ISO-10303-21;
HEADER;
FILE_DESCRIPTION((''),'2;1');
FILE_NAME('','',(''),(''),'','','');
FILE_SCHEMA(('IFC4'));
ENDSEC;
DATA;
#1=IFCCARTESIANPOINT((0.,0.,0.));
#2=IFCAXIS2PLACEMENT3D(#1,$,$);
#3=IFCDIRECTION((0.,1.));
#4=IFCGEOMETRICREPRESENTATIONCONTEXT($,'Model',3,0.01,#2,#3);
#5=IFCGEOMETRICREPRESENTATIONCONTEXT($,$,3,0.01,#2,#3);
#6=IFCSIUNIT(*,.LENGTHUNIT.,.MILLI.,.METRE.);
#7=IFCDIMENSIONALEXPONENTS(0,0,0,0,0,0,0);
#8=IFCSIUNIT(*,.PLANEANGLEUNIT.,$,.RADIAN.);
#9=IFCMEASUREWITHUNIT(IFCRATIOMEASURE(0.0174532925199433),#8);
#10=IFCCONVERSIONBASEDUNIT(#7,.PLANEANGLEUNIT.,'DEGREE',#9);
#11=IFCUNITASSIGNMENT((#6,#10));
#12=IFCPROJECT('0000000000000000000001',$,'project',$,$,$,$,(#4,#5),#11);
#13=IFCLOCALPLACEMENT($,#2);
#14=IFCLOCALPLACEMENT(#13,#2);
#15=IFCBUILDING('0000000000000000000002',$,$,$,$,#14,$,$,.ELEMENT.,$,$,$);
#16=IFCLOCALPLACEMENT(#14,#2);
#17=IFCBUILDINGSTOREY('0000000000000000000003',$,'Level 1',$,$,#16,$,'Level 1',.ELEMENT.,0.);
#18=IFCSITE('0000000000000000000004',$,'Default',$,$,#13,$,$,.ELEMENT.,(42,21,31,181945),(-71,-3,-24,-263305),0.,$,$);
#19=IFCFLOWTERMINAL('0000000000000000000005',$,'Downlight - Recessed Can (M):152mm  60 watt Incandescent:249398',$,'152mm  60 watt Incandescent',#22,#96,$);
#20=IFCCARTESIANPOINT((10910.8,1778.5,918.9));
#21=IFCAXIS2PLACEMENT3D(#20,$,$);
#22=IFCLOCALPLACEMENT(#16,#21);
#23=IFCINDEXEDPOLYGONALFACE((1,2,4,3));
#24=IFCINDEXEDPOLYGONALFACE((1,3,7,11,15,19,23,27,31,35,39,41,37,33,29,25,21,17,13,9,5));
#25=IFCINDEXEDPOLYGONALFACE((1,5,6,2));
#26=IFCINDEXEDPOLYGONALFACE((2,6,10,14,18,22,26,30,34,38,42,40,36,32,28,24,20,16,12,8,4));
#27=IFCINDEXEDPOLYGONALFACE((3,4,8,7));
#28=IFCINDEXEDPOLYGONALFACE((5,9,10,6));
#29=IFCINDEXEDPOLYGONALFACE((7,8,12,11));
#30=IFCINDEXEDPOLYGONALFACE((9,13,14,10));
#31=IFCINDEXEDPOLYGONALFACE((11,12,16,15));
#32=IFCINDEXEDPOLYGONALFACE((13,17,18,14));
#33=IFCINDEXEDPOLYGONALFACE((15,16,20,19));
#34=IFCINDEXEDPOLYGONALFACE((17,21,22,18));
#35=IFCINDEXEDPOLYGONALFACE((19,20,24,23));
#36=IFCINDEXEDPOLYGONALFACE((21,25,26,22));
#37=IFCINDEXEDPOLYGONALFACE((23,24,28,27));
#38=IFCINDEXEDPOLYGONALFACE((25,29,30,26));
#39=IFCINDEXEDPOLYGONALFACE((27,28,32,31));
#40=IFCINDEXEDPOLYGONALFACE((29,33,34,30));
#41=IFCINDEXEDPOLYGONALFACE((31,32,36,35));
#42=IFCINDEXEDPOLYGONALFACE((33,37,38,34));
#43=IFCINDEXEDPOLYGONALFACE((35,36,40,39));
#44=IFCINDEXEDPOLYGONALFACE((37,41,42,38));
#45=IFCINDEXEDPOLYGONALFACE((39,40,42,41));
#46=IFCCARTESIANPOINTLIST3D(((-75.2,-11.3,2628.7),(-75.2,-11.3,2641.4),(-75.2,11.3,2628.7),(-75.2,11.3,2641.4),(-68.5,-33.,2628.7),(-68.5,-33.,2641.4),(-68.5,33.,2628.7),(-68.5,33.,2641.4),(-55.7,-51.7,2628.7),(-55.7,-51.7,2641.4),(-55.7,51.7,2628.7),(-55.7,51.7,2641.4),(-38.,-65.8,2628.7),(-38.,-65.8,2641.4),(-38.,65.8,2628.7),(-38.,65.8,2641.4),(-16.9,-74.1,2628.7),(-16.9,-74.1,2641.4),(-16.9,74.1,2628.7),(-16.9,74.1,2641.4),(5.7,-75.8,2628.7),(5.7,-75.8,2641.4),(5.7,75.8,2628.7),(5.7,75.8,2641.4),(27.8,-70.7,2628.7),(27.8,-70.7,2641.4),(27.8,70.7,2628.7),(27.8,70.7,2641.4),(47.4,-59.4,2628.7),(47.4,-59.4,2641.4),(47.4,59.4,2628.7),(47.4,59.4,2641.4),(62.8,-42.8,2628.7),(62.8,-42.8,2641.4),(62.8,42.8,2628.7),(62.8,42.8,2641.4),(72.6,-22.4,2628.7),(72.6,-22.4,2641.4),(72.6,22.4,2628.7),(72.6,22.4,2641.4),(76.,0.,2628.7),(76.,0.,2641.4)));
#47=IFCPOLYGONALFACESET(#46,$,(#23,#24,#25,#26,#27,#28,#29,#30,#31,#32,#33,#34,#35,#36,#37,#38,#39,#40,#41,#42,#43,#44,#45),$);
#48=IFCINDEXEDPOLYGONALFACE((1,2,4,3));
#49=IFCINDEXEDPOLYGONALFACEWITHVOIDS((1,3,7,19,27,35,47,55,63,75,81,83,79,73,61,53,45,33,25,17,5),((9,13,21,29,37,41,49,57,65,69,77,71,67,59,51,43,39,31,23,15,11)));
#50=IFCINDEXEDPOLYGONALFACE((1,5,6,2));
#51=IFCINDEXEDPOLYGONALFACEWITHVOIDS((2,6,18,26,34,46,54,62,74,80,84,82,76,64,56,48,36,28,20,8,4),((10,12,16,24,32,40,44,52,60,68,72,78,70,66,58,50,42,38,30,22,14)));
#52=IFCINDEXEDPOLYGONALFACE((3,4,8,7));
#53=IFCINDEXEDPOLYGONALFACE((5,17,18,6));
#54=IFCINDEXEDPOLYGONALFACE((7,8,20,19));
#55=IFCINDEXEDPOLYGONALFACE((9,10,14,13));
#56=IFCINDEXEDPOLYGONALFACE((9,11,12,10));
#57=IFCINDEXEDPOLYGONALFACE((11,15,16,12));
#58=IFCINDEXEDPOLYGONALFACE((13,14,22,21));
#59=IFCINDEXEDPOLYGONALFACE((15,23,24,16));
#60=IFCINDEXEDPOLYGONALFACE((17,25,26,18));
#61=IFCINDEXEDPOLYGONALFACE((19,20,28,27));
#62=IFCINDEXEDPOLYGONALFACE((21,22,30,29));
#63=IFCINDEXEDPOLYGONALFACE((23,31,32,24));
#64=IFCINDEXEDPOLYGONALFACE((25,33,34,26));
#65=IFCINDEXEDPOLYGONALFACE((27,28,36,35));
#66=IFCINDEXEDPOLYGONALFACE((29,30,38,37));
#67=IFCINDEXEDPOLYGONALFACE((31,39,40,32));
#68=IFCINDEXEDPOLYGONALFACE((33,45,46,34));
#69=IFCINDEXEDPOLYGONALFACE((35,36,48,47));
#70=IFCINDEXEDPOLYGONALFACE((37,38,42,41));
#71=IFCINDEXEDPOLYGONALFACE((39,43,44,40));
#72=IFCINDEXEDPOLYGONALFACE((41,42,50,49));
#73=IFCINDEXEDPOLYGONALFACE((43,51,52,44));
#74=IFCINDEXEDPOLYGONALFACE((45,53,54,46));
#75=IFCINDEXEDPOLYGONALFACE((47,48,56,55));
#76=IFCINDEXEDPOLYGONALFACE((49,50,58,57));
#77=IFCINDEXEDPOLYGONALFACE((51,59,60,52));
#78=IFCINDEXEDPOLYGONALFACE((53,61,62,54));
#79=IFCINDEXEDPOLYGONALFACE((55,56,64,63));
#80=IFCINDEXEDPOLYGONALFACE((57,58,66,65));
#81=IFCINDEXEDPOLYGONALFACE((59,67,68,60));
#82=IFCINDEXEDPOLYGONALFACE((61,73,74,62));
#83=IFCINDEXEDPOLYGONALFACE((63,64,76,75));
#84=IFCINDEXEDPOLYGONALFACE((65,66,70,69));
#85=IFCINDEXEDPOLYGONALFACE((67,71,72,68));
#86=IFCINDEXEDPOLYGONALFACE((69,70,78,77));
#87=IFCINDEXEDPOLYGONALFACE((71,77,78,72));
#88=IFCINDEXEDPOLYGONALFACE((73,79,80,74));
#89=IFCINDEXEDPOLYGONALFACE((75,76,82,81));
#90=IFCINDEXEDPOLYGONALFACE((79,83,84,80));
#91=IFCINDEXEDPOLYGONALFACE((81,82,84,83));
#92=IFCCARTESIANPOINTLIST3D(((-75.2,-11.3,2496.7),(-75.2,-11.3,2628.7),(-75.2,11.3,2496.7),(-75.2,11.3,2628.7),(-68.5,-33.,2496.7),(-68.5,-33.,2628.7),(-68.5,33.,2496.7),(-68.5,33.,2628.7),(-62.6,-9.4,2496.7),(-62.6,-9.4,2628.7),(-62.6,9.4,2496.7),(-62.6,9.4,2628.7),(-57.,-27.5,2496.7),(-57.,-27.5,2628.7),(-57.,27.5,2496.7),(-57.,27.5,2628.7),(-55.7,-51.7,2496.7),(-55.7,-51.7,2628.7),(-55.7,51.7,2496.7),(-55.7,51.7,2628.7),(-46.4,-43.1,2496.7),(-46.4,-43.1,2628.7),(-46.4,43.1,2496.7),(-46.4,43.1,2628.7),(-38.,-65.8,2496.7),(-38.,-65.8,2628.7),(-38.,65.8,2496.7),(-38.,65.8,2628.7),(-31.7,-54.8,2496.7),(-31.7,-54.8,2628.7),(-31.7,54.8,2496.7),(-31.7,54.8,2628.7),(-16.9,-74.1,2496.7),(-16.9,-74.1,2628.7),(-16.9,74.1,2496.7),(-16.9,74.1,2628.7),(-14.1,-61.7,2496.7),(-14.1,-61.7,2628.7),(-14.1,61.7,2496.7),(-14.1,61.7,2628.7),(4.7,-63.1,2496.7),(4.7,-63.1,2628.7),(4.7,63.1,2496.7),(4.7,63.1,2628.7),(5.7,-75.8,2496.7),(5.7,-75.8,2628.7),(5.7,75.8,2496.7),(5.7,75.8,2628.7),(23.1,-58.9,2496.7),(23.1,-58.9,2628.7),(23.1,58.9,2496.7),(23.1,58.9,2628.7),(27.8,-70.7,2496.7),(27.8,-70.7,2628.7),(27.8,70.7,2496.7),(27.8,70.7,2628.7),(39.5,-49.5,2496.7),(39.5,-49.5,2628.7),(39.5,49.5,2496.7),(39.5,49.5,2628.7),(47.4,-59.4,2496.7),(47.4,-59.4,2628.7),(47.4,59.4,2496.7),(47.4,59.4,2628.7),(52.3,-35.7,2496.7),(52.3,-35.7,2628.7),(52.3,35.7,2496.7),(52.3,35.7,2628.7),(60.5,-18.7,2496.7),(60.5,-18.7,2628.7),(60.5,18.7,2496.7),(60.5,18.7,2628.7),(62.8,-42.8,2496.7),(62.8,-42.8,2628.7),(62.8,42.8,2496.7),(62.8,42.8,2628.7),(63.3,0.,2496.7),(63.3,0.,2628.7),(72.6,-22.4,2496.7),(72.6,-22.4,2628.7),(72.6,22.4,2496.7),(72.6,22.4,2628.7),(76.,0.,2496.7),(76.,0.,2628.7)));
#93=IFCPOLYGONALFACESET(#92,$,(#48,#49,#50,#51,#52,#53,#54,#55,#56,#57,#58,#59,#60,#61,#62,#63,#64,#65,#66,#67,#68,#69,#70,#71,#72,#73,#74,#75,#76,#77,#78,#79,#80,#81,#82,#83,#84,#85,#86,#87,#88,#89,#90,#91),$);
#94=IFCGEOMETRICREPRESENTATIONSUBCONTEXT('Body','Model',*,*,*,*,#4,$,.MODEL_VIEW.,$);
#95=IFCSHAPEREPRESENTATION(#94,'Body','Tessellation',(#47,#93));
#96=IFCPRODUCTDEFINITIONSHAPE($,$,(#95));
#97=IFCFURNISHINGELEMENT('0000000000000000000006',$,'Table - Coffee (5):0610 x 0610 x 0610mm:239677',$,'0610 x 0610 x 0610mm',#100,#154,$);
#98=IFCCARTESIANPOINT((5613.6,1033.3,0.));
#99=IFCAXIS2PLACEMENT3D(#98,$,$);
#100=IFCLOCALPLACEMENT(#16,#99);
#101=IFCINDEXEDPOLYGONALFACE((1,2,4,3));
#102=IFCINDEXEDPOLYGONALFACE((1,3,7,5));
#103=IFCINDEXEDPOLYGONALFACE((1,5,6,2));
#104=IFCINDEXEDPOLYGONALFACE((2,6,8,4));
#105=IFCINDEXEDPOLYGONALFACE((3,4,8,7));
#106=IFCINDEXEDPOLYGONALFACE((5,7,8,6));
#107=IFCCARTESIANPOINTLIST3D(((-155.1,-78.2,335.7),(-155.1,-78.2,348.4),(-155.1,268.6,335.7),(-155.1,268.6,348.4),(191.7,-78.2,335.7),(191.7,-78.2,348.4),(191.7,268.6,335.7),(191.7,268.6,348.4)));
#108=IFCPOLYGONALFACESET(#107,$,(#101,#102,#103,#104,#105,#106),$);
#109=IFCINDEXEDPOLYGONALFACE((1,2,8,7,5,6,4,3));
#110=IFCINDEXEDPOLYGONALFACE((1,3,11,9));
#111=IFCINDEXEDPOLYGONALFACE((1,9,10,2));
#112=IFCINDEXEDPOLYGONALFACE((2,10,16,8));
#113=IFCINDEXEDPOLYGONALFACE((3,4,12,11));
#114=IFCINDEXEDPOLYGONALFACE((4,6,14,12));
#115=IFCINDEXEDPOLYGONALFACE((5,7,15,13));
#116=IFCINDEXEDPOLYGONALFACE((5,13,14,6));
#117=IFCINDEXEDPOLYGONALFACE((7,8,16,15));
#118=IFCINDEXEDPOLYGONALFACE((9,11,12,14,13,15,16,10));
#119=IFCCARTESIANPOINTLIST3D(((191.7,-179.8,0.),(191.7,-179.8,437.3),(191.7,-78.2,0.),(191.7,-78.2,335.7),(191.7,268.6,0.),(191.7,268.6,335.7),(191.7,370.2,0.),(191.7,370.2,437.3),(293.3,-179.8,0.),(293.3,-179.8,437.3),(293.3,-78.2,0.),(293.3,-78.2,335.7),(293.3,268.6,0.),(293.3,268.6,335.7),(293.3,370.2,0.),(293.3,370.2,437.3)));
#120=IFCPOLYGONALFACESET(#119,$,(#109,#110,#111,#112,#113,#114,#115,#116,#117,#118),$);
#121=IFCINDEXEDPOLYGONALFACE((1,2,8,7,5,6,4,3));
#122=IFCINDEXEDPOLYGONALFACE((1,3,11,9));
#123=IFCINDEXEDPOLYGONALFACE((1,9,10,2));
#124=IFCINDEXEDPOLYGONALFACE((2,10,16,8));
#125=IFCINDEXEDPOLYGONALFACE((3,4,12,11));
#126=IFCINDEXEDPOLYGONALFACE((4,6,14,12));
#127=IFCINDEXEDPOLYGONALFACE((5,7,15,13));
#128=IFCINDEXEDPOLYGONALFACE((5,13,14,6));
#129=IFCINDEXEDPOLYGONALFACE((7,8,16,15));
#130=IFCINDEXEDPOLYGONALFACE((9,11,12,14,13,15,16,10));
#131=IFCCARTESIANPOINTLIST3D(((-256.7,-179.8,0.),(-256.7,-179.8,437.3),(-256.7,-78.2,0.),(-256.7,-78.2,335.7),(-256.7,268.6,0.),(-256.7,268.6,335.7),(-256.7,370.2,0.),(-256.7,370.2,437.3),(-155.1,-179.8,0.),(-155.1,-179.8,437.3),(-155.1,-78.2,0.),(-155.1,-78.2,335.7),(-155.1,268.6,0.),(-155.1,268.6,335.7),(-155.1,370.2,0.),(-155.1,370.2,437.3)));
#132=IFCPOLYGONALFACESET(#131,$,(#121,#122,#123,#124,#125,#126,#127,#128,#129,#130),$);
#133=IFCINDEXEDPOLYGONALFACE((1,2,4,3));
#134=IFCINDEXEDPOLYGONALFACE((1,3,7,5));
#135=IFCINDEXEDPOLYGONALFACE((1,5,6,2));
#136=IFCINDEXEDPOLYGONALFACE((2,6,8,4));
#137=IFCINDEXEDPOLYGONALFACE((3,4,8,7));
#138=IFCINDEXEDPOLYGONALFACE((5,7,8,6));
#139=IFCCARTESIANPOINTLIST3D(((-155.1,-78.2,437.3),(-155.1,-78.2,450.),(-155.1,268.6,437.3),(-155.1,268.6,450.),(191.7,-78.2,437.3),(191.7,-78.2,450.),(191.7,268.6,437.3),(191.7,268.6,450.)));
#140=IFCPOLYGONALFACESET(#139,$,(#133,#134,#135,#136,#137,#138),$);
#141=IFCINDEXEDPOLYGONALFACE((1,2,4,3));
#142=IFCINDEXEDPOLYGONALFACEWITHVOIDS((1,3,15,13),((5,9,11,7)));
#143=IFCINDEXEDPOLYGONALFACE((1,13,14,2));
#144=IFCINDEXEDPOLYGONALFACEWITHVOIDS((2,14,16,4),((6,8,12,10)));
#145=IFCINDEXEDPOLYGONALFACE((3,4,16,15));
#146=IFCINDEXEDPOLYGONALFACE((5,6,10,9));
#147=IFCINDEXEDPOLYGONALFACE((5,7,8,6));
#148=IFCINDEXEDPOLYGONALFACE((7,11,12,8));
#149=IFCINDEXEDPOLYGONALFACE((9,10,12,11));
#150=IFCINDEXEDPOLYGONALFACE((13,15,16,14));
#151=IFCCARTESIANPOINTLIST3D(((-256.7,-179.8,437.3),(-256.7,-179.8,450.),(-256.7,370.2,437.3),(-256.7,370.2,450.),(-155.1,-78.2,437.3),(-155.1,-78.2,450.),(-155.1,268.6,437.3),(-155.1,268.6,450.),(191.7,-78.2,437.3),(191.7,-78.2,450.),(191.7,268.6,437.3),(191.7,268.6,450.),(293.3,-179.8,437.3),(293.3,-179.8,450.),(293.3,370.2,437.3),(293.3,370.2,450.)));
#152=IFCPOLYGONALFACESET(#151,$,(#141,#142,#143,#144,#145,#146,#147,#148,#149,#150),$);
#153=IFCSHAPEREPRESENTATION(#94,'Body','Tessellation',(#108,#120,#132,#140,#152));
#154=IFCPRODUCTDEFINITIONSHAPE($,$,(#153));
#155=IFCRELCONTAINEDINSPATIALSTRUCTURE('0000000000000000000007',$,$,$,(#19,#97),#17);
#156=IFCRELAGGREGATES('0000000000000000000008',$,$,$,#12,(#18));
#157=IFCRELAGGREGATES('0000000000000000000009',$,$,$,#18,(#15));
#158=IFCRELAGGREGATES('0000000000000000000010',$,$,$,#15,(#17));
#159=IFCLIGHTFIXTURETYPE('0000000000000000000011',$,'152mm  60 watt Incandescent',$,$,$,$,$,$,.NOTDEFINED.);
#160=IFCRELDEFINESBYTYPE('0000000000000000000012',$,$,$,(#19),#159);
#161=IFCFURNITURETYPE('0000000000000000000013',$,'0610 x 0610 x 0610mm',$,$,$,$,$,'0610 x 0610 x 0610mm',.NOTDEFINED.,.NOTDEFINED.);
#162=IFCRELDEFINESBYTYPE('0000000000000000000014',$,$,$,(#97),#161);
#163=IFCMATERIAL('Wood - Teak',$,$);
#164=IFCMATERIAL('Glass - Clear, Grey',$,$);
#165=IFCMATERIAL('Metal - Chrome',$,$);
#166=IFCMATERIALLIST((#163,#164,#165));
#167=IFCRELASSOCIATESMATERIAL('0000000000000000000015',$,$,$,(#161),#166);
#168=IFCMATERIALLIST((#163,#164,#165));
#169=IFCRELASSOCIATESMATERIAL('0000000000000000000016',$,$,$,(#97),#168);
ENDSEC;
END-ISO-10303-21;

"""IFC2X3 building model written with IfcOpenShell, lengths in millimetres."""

from ifc_helpers import new_model, entity, si_unit, converted_unit, direction, frame, frame_2d, origin, origin_2d_with_axis, place, context, subcontext, project, spatial, polyline, rectangle, circle, hollow_circle, outline, extrude, source, transform, mapped, material, material_list, type_object, type_shapes, element, save


model = new_model("IFC2X3")

# Units and contexts
model_context = context("Model", 3, precision=0.01, world=origin(), true_north=direction((0.0, 1.0)))
context_of_model = context(None, 3, precision=0.01, world=origin(), true_north=direction((0.0, 1.0)))
body_context = subcontext(model_context, "Body", "Model", "MODEL_VIEW")
ifc_project = project(units=[si_unit("LENGTHUNIT", "METRE", prefix="MILLI"), converted_unit("PLANEANGLEUNIT", "DEGREE", entity("IfcRatioMeasure", 0.0174532925199433), si_unit("PLANEANGLEUNIT", "RADIAN"), dimensions=[0, 0, 0, 0, 0, 0, 0])], contexts=[model_context, context_of_model])

# Site, building, storey
site_placement = place(None, origin())
site = spatial("IfcSite", under=ifc_project, at=site_placement, Name="Default", CompositionType="ELEMENT", RefLatitude=(42, 21, 31, 181945), RefLongitude=(-71, -3, -24, -263305), RefElevation=0.0)
building_placement = place(site_placement, origin())
building = spatial("IfcBuilding", under=site, at=building_placement, CompositionType="ELEMENT")
storey_placement = place(building_placement, origin())
storey = spatial("IfcBuildingStorey", under=building, at=storey_placement, Name="Level 1", LongName="Level 1", CompositionType="ELEMENT", Elevation=0.0)

# Flow terminal
ifc_material_1 = material(Name="Metal - Chrome")
light_fixture_type_1 = type_object("IfcLightFixtureType", Name="152mm  60 watt Incandescent", PredefinedType="NOTDEFINED")
shared_shape_1 = source(origin(), body_context, "Body", "SweptSolid", [
    extrude(circle(Radius=76.0, at=frame_2d((0.0, 0.0), x_axis=(1.0, 0.0))), frame((0.0, 0.0, 2628.7)), (0.0, 0.0, 1.0), 12.7),
    extrude(hollow_circle(Radius=76.0, WallThickness=12.7, at=frame_2d((0.0, 0.0), x_axis=(1.0, 0.0))), frame((0.0, 0.0, 2496.7)), (0.0, 0.0, 1.0), 132.0),
])
type_shapes(light_fixture_type_1, [shared_shape_1])
for number, where, name in (
    (1, (10910.8, 1778.5, 918.9), "Downlight - Recessed Can (M):152mm  60 watt Incandescent:249398"),
):
    element("IfcFlowTerminal", number, at=place(storey_placement, frame(where)), inside=storey, type_object=light_fixture_type_1, Name=name, ObjectType="152mm  60 watt Incandescent", context=body_context, shape_type="MappedRepresentation", body=[
        mapped(shared_shape_1, transform((0.0, 0.0, 0.0), scale=1.0)),
    ])

# Furnishing element
ifc_material_2 = material(Name="Wood - Teak")
ifc_material_3 = material(Name="Glass - Clear, Grey")
ifc_material_list_1 = material_list([ifc_material_2, ifc_material_3, ifc_material_1])
ifc_material_list_2 = material_list([ifc_material_2, ifc_material_3, ifc_material_1])
furniture_type_1 = type_object("IfcFurnitureType", Name="0610 x 0610 x 0610mm", ElementType="0610 x 0610 x 0610mm", AssemblyPlace="NOTDEFINED", material=ifc_material_list_2)
shared_shape_2 = source(origin(), body_context, "Body", "SweptSolid", [
    extrude(rectangle(XDim=346.8, YDim=346.8, at=origin_2d_with_axis()), frame((18.3, 95.2, 335.7), z_axis=(0.0, 0.0, 1.0), x_axis=(-1.0, 0.0, 0.0)), (0.0, 0.0, 1.0), 12.7),
    extrude(outline(polyline([(-193.2, -275.0), (244.0, -275.0), (244.0, 275.0), (-193.2, 275.0), (-193.2, 173.4), (142.5, 173.4), (142.5, -173.4), (-193.2, -173.4), (-193.2, -275.0)])), frame((191.7, 95.2, 193.2), z_axis=(1.0, 0.0, 0.0), x_axis=(0.0, 0.0, 1.0)), (0.0, 0.0, 1.0), 101.6),
    extrude(outline(polyline([(-275.0, -244.1), (275.0, -244.1), (275.0, 193.3), (173.4, 193.3), (173.4, -142.4), (-173.4, -142.4), (-173.4, 193.3), (-275.0, 193.3), (-275.0, -244.1)])), frame((-256.7, 95.2, 193.3), z_axis=(1.0, 0.0, 0.0), x_axis=(0.0, -1.0, 0.0)), (0.0, 0.0, 1.0), 101.6),
    extrude(rectangle(XDim=346.8, YDim=346.8, at=origin_2d_with_axis()), frame((18.3, 95.2, 437.3), z_axis=(0.0, 0.0, 1.0), x_axis=(-1.0, 0.0, 0.0)), (0.0, 0.0, 1.0), 12.7),
    extrude(outline(polyline([(-275.0, -275.0), (275.0, -275.0), (275.0, 275.0), (-275.0, 275.0), (-275.0, -275.0)]), holes=[polyline([(-173.4, -173.4), (-173.4, 173.4), (173.4, 173.4), (173.4, -173.4), (-173.4, -173.4)])]), frame((18.3, 95.2, 437.3), z_axis=(0.0, 0.0, 1.0), x_axis=(-1.0, 0.0, 0.0)), (0.0, 0.0, 1.0), 12.7),
])
type_shapes(furniture_type_1, [shared_shape_2])
furnishing_1_placement = place(storey_placement, frame((5613.6, 1033.3, 0.0)))
element("IfcFurnishingElement", 2, at=furnishing_1_placement, inside=storey, type_object=furniture_type_1, material=ifc_material_list_1, Name="Table - Coffee (5):0610 x 0610 x 0610mm:239677", ObjectType="0610 x 0610 x 0610mm", context=body_context, shape_type="MappedRepresentation", body=[
    mapped(shared_shape_2, transform((0.0, 0.0, 0.0), scale=1.0)),
])

save(model, "model.ifc")
